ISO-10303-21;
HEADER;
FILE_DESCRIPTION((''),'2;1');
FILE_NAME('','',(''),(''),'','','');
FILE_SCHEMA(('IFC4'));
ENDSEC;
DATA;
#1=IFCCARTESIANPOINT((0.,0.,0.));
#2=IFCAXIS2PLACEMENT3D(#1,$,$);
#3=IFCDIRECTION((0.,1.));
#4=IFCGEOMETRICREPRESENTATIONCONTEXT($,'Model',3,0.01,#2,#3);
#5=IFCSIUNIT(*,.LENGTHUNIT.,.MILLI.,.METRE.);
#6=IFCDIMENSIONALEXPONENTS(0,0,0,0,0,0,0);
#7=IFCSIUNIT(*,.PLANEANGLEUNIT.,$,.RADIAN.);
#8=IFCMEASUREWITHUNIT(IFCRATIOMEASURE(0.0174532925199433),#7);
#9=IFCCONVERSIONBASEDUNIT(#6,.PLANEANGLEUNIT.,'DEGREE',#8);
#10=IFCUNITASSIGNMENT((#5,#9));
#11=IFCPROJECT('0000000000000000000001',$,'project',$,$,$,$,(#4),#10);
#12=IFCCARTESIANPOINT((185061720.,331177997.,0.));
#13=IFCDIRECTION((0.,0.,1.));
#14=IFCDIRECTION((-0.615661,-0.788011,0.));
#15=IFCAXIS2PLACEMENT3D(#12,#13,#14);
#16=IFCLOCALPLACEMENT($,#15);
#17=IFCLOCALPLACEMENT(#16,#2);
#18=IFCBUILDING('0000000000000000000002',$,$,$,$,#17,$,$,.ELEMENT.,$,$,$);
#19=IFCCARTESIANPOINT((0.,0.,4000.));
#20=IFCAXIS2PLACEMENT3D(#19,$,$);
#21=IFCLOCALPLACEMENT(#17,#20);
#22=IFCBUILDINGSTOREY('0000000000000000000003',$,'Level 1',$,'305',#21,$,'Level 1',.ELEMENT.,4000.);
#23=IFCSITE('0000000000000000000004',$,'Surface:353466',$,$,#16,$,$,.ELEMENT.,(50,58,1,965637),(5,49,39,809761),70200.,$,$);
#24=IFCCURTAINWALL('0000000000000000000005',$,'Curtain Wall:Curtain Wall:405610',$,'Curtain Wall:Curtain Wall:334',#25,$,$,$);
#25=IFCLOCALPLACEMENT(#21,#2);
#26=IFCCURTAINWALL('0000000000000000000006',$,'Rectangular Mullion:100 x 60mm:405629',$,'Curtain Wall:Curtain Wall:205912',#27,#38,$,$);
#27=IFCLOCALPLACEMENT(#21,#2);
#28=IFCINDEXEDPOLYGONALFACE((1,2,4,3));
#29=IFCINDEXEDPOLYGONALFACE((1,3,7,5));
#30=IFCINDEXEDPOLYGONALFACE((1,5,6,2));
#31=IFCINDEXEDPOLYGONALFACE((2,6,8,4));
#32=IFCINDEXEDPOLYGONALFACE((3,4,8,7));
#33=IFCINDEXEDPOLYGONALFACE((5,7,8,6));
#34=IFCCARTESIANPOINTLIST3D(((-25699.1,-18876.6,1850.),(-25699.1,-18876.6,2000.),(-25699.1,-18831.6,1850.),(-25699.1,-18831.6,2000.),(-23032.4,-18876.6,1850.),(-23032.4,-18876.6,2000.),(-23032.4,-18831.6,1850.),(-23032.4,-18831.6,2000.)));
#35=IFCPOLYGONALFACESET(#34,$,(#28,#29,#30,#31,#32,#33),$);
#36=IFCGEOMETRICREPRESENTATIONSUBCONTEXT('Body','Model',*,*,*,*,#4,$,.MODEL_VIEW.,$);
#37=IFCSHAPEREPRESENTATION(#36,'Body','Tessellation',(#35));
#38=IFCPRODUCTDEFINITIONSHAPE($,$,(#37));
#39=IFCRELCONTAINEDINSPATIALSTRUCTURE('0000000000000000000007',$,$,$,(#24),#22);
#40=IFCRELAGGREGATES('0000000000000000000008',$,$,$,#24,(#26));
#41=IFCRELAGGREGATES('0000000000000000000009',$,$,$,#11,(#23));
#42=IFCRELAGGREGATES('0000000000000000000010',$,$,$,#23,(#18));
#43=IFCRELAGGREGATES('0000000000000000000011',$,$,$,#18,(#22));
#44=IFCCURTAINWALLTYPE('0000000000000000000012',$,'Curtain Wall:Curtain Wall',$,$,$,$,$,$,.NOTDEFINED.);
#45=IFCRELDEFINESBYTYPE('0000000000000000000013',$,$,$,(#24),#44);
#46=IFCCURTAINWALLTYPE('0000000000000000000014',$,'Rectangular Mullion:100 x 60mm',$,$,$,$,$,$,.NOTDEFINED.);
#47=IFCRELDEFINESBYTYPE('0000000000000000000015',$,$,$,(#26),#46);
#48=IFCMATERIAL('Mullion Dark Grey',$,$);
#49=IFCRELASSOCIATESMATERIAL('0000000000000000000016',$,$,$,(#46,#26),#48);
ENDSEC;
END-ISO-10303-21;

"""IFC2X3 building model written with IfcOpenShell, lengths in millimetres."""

from ifc_helpers import new_model, entity, si_unit, converted_unit, direction, frame, frame_2d, origin, place, context, subcontext, project, spatial, rectangle, extrude, source, transform, mapped, material, type_object, type_shapes, element, aggregate, save


model = new_model("IFC2X3")

# Units and contexts
model_context = context("Model", 3, precision=0.01, world=origin(), true_north=direction((0.0, 1.0)))
body_context = subcontext(model_context, "Body", "Model", "MODEL_VIEW")
ifc_project = project(units=[si_unit("LENGTHUNIT", "METRE", prefix="MILLI"), converted_unit("PLANEANGLEUNIT", "DEGREE", entity("IfcRatioMeasure", 0.0174532925199433), si_unit("PLANEANGLEUNIT", "RADIAN"), dimensions=[0, 0, 0, 0, 0, 0, 0])], contexts=[model_context])

# Site, building, storey
site_placement = place(None, frame((185061720.0, 331177997.0, 0.0), z_axis=(0.0, 0.0, 1.0), x_axis=(-0.615661, -0.788011, 0.0)))
site = spatial("IfcSite", under=ifc_project, at=site_placement, Name="Surface:353466", CompositionType="ELEMENT", RefLatitude=(50, 58, 1, 965637), RefLongitude=(5, 49, 39, 809761), RefElevation=70200.0)
building_placement = place(site_placement, origin())
building = spatial("IfcBuilding", under=site, at=building_placement, CompositionType="ELEMENT")
storey_placement = place(building_placement, frame((0.0, 0.0, 4000.0)))
storey = spatial("IfcBuildingStorey", under=building, at=storey_placement, Name="Level 1", ObjectType="305", LongName="Level 1", CompositionType="ELEMENT", Elevation=4000.0)

# Curtain walls
curtain_wall_type_1 = type_object("IfcCurtainWallType", Name="Curtain Wall:Curtain Wall", PredefinedType="NOTDEFINED")
ifc_material_1 = material(Name="Mullion Dark Grey")
curtain_wall_1_placement = place(storey_placement, frame((0.0, 0.0, -4000.0)))
curtain_wall_1 = element("IfcCurtainWall", 1, at=curtain_wall_1_placement, inside=storey, type_object=curtain_wall_type_1, Name="Curtain Wall:Curtain Wall:405610", ObjectType="Curtain Wall:Curtain Wall:334")
curtain_wall_type_2 = type_object("IfcCurtainWallType", Name="Rectangular Mullion:100 x 60mm", PredefinedType="NOTDEFINED", material=ifc_material_1)
shared_shape_1 = source(origin(), body_context, "Body", "SweptSolid", [
    extrude(rectangle(XDim=150.0, YDim=45.0, at=frame_2d((0.0, 0.0), x_axis=(1.0, 0.0))), frame((-75.0, -7.5, -2666.7)), (0.0, 0.0, 1.0), 2666.7),
])
type_shapes(curtain_wall_type_2, [shared_shape_1])
curtain_wall_2_placement = place(storey_placement, frame((-23032.4, -18861.6, 2000.0), z_axis=(1.0, 0.0, 0.0), x_axis=(0.0, 0.0, 1.0)))
curtain_wall_2 = element("IfcCurtainWall", 2, at=curtain_wall_2_placement, type_object=curtain_wall_type_2, material=ifc_material_1, Name="Rectangular Mullion:100 x 60mm:405629", ObjectType="Curtain Wall:Curtain Wall:205912", context=body_context, shape_type="MappedRepresentation", body=[
    mapped(shared_shape_1, transform((0.0, 0.0, 0.0), scale=1.0)),
])
aggregate(curtain_wall_1, [curtain_wall_2])

save(model, "model.ifc")
